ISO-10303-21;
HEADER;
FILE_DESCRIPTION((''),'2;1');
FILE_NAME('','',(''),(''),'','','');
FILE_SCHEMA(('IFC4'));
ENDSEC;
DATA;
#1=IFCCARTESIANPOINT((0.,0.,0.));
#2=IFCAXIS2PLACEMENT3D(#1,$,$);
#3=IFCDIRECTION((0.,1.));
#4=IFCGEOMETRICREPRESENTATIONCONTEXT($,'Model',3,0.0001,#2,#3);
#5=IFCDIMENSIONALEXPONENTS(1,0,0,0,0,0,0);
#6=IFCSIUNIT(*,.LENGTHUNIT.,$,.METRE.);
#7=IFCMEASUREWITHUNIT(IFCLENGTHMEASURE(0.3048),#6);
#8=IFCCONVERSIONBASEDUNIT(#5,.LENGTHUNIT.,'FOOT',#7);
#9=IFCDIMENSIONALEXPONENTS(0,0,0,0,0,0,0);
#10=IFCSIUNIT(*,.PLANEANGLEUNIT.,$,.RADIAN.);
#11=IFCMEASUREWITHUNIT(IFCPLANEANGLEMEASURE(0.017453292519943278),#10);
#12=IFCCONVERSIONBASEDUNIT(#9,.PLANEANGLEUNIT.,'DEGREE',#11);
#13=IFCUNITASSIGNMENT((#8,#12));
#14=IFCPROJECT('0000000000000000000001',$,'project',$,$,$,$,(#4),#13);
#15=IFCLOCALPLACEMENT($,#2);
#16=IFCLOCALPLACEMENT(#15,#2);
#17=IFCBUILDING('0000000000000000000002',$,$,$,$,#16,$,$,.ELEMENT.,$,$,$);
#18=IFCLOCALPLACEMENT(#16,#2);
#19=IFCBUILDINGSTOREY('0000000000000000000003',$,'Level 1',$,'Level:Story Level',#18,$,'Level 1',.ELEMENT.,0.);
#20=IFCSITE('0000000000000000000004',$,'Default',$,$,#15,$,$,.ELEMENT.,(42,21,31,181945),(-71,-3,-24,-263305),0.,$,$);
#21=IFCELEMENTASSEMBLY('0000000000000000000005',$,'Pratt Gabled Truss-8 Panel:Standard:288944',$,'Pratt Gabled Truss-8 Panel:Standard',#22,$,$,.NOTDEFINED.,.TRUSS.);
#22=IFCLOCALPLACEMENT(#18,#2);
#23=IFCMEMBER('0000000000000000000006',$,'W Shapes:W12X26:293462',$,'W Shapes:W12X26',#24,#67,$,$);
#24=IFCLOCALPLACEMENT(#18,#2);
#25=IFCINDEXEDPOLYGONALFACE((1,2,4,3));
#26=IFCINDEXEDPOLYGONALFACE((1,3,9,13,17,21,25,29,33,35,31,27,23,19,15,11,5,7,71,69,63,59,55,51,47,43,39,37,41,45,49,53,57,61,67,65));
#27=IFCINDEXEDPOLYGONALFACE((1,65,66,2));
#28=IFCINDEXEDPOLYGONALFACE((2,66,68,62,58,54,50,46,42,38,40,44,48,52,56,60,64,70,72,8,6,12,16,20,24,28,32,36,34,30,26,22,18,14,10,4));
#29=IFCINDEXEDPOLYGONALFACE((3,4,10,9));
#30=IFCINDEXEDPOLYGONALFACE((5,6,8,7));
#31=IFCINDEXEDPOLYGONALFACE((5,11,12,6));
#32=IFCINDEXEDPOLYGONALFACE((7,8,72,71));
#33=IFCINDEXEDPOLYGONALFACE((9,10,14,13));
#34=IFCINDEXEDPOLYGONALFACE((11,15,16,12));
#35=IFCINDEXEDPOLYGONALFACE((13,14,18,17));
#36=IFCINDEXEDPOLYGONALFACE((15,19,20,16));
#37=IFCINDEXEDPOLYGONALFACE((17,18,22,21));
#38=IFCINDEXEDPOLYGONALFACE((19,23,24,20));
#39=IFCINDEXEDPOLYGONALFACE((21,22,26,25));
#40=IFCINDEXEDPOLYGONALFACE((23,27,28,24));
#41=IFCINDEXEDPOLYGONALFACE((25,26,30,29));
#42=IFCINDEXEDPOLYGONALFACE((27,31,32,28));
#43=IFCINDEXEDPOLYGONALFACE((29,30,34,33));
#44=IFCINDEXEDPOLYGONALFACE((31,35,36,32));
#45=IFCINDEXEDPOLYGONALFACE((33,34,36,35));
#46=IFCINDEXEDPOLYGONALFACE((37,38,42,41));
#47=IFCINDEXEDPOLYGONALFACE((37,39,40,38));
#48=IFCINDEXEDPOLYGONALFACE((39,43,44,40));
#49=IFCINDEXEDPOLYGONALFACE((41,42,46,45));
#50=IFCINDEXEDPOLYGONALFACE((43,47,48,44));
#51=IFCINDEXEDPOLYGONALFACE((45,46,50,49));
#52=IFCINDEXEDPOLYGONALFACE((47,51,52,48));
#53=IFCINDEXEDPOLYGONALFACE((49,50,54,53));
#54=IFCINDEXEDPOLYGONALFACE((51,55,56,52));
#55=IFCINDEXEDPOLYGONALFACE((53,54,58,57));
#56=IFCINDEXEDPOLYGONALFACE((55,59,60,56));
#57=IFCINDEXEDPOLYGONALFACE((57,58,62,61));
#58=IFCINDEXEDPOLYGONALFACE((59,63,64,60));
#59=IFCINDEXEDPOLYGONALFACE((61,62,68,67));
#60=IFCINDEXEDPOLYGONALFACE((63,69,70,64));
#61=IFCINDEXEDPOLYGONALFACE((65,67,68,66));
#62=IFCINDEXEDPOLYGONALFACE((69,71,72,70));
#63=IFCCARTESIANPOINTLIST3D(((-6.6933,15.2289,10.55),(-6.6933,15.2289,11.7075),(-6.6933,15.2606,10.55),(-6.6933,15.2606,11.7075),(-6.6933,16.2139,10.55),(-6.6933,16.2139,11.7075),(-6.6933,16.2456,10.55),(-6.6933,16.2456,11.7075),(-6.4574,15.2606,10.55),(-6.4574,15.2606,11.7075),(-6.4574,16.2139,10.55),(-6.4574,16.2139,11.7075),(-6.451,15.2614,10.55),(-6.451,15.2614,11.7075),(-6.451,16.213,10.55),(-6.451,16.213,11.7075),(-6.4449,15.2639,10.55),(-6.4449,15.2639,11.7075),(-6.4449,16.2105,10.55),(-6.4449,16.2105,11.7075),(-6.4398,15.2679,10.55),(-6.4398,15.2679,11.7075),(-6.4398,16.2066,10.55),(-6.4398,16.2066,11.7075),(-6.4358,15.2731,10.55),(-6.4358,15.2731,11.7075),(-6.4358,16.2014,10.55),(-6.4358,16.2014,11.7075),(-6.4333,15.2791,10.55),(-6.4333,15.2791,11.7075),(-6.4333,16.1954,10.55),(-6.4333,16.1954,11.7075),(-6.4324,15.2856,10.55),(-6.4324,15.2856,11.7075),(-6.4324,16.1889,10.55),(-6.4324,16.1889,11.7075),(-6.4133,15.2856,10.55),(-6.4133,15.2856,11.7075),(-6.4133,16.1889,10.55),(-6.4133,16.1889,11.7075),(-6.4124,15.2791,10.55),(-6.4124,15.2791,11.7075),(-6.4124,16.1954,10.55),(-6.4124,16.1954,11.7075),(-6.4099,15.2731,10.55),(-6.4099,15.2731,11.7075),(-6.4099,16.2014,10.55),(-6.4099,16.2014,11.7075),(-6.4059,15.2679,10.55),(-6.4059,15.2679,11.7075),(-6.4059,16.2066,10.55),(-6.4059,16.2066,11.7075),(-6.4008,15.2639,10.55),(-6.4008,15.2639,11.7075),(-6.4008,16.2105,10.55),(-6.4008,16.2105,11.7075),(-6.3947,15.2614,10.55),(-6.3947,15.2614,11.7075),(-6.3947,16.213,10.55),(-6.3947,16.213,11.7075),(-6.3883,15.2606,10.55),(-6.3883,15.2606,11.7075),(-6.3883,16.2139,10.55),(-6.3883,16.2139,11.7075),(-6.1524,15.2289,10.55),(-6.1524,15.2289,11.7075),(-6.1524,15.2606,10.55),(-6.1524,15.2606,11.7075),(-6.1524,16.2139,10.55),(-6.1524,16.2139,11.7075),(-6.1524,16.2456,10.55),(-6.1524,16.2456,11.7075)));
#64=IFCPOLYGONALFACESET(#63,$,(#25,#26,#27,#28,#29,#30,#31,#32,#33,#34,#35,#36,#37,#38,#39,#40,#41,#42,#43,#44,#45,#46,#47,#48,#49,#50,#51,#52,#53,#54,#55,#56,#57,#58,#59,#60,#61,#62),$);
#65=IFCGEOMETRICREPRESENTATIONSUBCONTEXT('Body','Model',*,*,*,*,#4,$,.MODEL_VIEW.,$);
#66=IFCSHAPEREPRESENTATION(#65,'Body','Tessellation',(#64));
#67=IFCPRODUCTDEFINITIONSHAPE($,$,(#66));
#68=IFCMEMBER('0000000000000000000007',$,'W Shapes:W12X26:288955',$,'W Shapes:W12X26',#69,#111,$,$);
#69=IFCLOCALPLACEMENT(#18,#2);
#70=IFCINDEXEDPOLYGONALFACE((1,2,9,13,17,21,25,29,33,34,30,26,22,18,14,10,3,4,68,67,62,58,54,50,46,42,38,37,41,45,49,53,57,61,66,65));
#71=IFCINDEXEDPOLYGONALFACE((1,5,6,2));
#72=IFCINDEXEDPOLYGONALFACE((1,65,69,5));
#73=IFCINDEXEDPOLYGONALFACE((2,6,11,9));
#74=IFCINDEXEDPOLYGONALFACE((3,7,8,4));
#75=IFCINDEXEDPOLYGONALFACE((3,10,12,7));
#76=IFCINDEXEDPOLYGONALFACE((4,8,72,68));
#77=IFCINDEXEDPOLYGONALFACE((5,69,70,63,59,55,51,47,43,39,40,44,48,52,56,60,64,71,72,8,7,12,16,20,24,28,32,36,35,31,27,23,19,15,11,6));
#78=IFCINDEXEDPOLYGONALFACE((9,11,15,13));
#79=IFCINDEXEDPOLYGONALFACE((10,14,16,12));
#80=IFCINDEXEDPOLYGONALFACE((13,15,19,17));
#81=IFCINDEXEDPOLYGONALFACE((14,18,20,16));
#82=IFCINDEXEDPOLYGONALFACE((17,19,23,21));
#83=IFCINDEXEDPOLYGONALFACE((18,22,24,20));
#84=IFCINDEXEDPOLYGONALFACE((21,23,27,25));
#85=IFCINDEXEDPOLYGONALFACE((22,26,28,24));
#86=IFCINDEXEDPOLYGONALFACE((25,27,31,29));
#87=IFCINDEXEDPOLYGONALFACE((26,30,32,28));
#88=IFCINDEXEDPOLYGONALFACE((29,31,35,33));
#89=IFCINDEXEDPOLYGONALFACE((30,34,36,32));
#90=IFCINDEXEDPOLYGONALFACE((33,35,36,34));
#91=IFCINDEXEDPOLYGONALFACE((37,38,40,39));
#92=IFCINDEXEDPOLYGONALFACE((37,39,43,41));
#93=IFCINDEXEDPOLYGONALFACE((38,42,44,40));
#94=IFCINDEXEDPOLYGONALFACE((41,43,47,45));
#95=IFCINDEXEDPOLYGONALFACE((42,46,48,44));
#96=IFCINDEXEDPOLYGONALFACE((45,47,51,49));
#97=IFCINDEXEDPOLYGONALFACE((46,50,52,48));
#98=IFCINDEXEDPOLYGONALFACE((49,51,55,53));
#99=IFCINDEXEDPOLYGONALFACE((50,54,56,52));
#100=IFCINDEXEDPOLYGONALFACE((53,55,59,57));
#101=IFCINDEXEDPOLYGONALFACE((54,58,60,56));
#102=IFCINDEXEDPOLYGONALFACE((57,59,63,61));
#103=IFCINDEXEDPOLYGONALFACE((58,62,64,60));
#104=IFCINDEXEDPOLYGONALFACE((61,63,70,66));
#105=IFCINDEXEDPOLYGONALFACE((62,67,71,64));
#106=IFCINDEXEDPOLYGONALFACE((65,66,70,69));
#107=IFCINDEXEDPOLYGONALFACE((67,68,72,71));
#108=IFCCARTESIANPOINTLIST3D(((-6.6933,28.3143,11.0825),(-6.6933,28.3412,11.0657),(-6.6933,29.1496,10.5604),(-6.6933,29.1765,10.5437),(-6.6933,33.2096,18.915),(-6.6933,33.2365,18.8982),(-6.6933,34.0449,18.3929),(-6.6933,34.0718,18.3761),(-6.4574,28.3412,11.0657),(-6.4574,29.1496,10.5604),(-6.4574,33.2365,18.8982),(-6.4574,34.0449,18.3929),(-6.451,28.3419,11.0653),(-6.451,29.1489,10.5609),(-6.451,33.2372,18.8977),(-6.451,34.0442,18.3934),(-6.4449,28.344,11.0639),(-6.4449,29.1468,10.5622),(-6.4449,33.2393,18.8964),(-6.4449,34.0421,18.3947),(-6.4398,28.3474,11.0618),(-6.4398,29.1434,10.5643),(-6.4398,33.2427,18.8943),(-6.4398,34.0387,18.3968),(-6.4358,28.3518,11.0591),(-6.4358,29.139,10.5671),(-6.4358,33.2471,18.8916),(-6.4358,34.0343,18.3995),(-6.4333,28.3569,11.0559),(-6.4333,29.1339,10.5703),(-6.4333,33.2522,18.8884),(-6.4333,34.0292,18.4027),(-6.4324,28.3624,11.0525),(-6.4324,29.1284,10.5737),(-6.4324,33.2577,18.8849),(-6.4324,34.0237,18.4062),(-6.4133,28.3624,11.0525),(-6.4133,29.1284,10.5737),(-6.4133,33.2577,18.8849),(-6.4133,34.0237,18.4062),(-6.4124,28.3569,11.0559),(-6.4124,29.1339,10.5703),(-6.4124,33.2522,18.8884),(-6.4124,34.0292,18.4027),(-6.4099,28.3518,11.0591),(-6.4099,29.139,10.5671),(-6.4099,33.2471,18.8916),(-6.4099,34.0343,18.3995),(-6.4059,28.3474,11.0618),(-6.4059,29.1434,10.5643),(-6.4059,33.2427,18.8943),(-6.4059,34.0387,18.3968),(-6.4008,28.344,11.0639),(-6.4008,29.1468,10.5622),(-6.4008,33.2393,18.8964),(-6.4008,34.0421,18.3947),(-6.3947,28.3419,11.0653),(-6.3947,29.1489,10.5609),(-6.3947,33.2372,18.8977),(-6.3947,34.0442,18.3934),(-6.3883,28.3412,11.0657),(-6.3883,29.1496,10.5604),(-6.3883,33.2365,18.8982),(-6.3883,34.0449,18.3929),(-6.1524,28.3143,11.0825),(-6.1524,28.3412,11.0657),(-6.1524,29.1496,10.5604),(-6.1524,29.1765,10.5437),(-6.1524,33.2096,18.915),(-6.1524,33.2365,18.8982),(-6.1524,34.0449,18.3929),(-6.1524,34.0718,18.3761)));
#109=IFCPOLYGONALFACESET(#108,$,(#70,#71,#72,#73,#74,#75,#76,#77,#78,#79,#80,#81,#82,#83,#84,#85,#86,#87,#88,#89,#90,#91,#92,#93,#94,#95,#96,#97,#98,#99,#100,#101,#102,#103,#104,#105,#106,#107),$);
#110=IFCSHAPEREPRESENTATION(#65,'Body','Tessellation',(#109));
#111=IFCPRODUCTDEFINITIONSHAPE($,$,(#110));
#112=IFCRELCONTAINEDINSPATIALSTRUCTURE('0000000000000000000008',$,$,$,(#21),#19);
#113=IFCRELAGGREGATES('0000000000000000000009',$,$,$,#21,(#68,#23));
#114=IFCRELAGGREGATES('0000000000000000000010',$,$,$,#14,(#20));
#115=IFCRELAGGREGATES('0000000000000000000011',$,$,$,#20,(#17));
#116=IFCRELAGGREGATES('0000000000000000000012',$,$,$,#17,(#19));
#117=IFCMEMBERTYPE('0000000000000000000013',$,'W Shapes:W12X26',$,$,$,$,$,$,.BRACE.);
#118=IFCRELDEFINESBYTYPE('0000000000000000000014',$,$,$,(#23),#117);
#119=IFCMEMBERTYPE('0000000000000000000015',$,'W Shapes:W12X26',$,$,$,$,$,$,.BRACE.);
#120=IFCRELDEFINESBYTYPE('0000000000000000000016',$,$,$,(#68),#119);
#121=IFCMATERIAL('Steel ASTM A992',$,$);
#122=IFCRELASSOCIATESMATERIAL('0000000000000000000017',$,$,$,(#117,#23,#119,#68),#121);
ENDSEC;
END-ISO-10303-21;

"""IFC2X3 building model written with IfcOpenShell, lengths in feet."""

from ifc_helpers import new_model, entity, si_unit, converted_unit, direction, frame, frame_2d, origin, place, context, subcontext, project, spatial, polyline, circle_curve, parameter, trimmed, segment, composite_curve, outline, extrude, source, transform, mapped, material, type_object, type_shapes, element, aggregate, save


model = new_model("IFC2X3")

# Units and contexts
model_context = context("Model", 3, precision=0.0001, world=origin(), true_north=direction((0.0, 1.0)))
body_context = subcontext(model_context, "Body", "Model", "MODEL_VIEW")
ifc_project = project(units=[converted_unit("LENGTHUNIT", "FOOT", entity("IfcLengthMeasure", 0.3048), si_unit("LENGTHUNIT", "METRE"), dimensions=[1, 0, 0, 0, 0, 0, 0]), converted_unit("PLANEANGLEUNIT", "DEGREE", entity("IfcPlaneAngleMeasure", 0.017453292519943278), si_unit("PLANEANGLEUNIT", "RADIAN"), dimensions=[0, 0, 0, 0, 0, 0, 0])], contexts=[model_context])

# Site, building, storey
site_placement = place(None, origin())
site = spatial("IfcSite", under=ifc_project, at=site_placement, Name="Default", CompositionType="ELEMENT", RefLatitude=(42, 21, 31, 181945), RefLongitude=(-71, -3, -24, -263305), RefElevation=0.0)
building_placement = place(site_placement, origin())
building = spatial("IfcBuilding", under=site, at=building_placement, CompositionType="ELEMENT")
storey_placement = place(building_placement, origin())
storey = spatial("IfcBuildingStorey", under=building, at=storey_placement, Name="Level 1", ObjectType="Level:Story Level", LongName="Level 1", CompositionType="ELEMENT", Elevation=0.0)

# Element assembly, members
assembly_placement = place(storey_placement, origin())
assembly = element("IfcElementAssembly", 1, at=assembly_placement, inside=storey, Name="Pratt Gabled Truss-8 Panel:Standard:288944", ObjectType="Pratt Gabled Truss-8 Panel:Standard", AssemblyPlace="NOTDEFINED", PredefinedType="TRUSS")
ifc_material = material(Name="Steel ASTM A992")
member_type_1 = type_object("IfcMemberType", Name="W Shapes:W12X26", PredefinedType="BRACE", material=ifc_material)
shared_shape_1 = source(origin(), body_context, "Body", "SweptSolid", [
    extrude(outline(composite_curve([segment(polyline([(-0.2704, -0.4767), (-0.2704, -0.5083)]), True, "CONTINUOUS"), segment(polyline([(-0.2704, -0.5083), (0.2704, -0.5083)]), True, "CONTINUOUS"), segment(polyline([(0.2704, -0.5083), (0.2704, -0.4767)]), True, "CONTINUOUS"), segment(polyline([(0.2704, -0.4767), (0.0346, -0.4767)]), True, "CONTINUOUS"), segment(trimmed(circle_curve(frame_2d((0.0346, -0.4517), x_axis=(0.0, -1.0)), 0.025), [parameter(270.0)], [parameter(360.0)], True, "PARAMETER"), False, "CONTINUOUS"), segment(polyline([(0.0096, -0.4517), (0.0096, 0.4517)]), True, "CONTINUOUS"), segment(trimmed(circle_curve(frame_2d((0.0346, 0.4517), x_axis=(-1.0, 0.0)), 0.025), [parameter(270.0)], [parameter(360.0)], True, "PARAMETER"), False, "CONTINUOUS"), segment(polyline([(0.0346, 0.4767), (0.2704, 0.4767)]), True, "CONTINUOUS"), segment(polyline([(0.2704, 0.4767), (0.2704, 0.5083)]), True, "CONTINUOUS"), segment(polyline([(0.2704, 0.5083), (-0.2704, 0.5083)]), True, "CONTINUOUS"), segment(polyline([(-0.2704, 0.5083), (-0.2704, 0.4767)]), True, "CONTINUOUS"), segment(polyline([(-0.2704, 0.4767), (-0.0346, 0.4767)]), True, "CONTINUOUS"), segment(trimmed(circle_curve(frame_2d((-0.0346, 0.4517), x_axis=(0.0, 1.0)), 0.025), [parameter(270.0)], [parameter(0.0)], True, "PARAMETER"), False, "CONTINUOUS"), segment(polyline([(-0.0096, 0.4517), (-0.0096, -0.4517)]), True, "CONTINUOUS"), segment(trimmed(circle_curve(frame_2d((-0.0346, -0.4517), x_axis=(1.0, 0.0)), 0.025), [parameter(270.0)], [parameter(0.0)], True, "PARAMETER"), False, "CONTINUOUS"), segment(polyline([(-0.0346, -0.4767), (-0.2704, -0.4767)]), True, "CONTINUOUS")], self_intersect=False)), frame((-0.7, 0.0, 0.0), z_axis=(-1.0, 0.0, 0.0), x_axis=(0.0, -1.0, 0.0)), (0.0, 0.0, -1.0), 1.1575),
])
type_shapes(member_type_1, [shared_shape_1])
member_1_placement = place(assembly_placement, frame((-6.4228, 15.7372, 11.25), z_axis=(0.0, 1.0, 0.0), x_axis=(0.0, 0.0, 1.0)))
member_1 = element("IfcMember", 2, at=member_1_placement, type_object=member_type_1, material=ifc_material, Name="W Shapes:W12X26:293462", ObjectType="W Shapes:W12X26", context=body_context, shape_type="MappedRepresentation", body=[
    mapped(shared_shape_1, transform((0.0, 0.0, 0.0), scale=1.0)),
])
member_type_2 = type_object("IfcMemberType", Name="W Shapes:W12X26", PredefinedType="BRACE", material=ifc_material)
shared_shape_2 = source(origin(), body_context, "Body", "SweptSolid", [
    extrude(outline(composite_curve([segment(polyline([(-0.2704, -0.4767), (-0.2704, -0.5083)]), True, "CONTINUOUS"), segment(polyline([(-0.2704, -0.5083), (0.2704, -0.5083)]), True, "CONTINUOUS"), segment(polyline([(0.2704, -0.5083), (0.2704, -0.4767)]), True, "CONTINUOUS"), segment(polyline([(0.2704, -0.4767), (0.0346, -0.4767)]), True, "CONTINUOUS"), segment(trimmed(circle_curve(frame_2d((0.0346, -0.4517), x_axis=(1.0, 0.0)), 0.025), [parameter(180.0)], [parameter(270.0)], True, "PARAMETER"), False, "CONTINUOUS"), segment(polyline([(0.0096, -0.4517), (0.0096, 0.4517)]), True, "CONTINUOUS"), segment(trimmed(circle_curve(frame_2d((0.0346, 0.4517), x_axis=(1.0, 0.0)), 0.025), [parameter(90.0)], [parameter(180.0)], True, "PARAMETER"), False, "CONTINUOUS"), segment(polyline([(0.0346, 0.4767), (0.2704, 0.4767)]), True, "CONTINUOUS"), segment(polyline([(0.2704, 0.4767), (0.2704, 0.5083)]), True, "CONTINUOUS"), segment(polyline([(0.2704, 0.5083), (-0.2704, 0.5083)]), True, "CONTINUOUS"), segment(polyline([(-0.2704, 0.5083), (-0.2704, 0.4767)]), True, "CONTINUOUS"), segment(polyline([(-0.2704, 0.4767), (-0.0346, 0.4767)]), True, "CONTINUOUS"), segment(trimmed(circle_curve(frame_2d((-0.0346, 0.4517), x_axis=(1.0, 0.0)), 0.025), [parameter(360.0)], [parameter(90.0)], True, "PARAMETER"), False, "CONTINUOUS"), segment(polyline([(-0.0096, 0.4517), (-0.0096, -0.4517)]), True, "CONTINUOUS"), segment(trimmed(circle_curve(frame_2d((-0.0346, -0.4517), x_axis=(1.0, 0.0)), 0.025), [parameter(270.0)], [parameter(360.0)], True, "PARAMETER"), False, "CONTINUOUS"), segment(polyline([(-0.0346, -0.4767), (-0.2704, -0.4767)]), True, "CONTINUOUS")], self_intersect=False)), frame((-4.9374, 0.0, 0.0), z_axis=(-1.0, 0.0, 0.0), x_axis=(0.0, -1.0, 0.0)), (0.0, 0.0, -1.0), 9.2364),
])
type_shapes(member_type_2, [shared_shape_2])
member_2_placement = place(assembly_placement, frame((-6.4228, 31.3622, 15.0), z_axis=(0.0, 0.847998, -0.529999), x_axis=(0.0, 0.529999, 0.847998)))
member_2 = element("IfcMember", 3, at=member_2_placement, type_object=member_type_2, material=ifc_material, Name="W Shapes:W12X26:288955", ObjectType="W Shapes:W12X26", context=body_context, shape_type="MappedRepresentation", body=[
    mapped(shared_shape_2, transform((0.0, 0.0, 0.0), scale=1.0)),
])
aggregate(assembly, [member_2, member_1])

save(model, "model.ifc")
